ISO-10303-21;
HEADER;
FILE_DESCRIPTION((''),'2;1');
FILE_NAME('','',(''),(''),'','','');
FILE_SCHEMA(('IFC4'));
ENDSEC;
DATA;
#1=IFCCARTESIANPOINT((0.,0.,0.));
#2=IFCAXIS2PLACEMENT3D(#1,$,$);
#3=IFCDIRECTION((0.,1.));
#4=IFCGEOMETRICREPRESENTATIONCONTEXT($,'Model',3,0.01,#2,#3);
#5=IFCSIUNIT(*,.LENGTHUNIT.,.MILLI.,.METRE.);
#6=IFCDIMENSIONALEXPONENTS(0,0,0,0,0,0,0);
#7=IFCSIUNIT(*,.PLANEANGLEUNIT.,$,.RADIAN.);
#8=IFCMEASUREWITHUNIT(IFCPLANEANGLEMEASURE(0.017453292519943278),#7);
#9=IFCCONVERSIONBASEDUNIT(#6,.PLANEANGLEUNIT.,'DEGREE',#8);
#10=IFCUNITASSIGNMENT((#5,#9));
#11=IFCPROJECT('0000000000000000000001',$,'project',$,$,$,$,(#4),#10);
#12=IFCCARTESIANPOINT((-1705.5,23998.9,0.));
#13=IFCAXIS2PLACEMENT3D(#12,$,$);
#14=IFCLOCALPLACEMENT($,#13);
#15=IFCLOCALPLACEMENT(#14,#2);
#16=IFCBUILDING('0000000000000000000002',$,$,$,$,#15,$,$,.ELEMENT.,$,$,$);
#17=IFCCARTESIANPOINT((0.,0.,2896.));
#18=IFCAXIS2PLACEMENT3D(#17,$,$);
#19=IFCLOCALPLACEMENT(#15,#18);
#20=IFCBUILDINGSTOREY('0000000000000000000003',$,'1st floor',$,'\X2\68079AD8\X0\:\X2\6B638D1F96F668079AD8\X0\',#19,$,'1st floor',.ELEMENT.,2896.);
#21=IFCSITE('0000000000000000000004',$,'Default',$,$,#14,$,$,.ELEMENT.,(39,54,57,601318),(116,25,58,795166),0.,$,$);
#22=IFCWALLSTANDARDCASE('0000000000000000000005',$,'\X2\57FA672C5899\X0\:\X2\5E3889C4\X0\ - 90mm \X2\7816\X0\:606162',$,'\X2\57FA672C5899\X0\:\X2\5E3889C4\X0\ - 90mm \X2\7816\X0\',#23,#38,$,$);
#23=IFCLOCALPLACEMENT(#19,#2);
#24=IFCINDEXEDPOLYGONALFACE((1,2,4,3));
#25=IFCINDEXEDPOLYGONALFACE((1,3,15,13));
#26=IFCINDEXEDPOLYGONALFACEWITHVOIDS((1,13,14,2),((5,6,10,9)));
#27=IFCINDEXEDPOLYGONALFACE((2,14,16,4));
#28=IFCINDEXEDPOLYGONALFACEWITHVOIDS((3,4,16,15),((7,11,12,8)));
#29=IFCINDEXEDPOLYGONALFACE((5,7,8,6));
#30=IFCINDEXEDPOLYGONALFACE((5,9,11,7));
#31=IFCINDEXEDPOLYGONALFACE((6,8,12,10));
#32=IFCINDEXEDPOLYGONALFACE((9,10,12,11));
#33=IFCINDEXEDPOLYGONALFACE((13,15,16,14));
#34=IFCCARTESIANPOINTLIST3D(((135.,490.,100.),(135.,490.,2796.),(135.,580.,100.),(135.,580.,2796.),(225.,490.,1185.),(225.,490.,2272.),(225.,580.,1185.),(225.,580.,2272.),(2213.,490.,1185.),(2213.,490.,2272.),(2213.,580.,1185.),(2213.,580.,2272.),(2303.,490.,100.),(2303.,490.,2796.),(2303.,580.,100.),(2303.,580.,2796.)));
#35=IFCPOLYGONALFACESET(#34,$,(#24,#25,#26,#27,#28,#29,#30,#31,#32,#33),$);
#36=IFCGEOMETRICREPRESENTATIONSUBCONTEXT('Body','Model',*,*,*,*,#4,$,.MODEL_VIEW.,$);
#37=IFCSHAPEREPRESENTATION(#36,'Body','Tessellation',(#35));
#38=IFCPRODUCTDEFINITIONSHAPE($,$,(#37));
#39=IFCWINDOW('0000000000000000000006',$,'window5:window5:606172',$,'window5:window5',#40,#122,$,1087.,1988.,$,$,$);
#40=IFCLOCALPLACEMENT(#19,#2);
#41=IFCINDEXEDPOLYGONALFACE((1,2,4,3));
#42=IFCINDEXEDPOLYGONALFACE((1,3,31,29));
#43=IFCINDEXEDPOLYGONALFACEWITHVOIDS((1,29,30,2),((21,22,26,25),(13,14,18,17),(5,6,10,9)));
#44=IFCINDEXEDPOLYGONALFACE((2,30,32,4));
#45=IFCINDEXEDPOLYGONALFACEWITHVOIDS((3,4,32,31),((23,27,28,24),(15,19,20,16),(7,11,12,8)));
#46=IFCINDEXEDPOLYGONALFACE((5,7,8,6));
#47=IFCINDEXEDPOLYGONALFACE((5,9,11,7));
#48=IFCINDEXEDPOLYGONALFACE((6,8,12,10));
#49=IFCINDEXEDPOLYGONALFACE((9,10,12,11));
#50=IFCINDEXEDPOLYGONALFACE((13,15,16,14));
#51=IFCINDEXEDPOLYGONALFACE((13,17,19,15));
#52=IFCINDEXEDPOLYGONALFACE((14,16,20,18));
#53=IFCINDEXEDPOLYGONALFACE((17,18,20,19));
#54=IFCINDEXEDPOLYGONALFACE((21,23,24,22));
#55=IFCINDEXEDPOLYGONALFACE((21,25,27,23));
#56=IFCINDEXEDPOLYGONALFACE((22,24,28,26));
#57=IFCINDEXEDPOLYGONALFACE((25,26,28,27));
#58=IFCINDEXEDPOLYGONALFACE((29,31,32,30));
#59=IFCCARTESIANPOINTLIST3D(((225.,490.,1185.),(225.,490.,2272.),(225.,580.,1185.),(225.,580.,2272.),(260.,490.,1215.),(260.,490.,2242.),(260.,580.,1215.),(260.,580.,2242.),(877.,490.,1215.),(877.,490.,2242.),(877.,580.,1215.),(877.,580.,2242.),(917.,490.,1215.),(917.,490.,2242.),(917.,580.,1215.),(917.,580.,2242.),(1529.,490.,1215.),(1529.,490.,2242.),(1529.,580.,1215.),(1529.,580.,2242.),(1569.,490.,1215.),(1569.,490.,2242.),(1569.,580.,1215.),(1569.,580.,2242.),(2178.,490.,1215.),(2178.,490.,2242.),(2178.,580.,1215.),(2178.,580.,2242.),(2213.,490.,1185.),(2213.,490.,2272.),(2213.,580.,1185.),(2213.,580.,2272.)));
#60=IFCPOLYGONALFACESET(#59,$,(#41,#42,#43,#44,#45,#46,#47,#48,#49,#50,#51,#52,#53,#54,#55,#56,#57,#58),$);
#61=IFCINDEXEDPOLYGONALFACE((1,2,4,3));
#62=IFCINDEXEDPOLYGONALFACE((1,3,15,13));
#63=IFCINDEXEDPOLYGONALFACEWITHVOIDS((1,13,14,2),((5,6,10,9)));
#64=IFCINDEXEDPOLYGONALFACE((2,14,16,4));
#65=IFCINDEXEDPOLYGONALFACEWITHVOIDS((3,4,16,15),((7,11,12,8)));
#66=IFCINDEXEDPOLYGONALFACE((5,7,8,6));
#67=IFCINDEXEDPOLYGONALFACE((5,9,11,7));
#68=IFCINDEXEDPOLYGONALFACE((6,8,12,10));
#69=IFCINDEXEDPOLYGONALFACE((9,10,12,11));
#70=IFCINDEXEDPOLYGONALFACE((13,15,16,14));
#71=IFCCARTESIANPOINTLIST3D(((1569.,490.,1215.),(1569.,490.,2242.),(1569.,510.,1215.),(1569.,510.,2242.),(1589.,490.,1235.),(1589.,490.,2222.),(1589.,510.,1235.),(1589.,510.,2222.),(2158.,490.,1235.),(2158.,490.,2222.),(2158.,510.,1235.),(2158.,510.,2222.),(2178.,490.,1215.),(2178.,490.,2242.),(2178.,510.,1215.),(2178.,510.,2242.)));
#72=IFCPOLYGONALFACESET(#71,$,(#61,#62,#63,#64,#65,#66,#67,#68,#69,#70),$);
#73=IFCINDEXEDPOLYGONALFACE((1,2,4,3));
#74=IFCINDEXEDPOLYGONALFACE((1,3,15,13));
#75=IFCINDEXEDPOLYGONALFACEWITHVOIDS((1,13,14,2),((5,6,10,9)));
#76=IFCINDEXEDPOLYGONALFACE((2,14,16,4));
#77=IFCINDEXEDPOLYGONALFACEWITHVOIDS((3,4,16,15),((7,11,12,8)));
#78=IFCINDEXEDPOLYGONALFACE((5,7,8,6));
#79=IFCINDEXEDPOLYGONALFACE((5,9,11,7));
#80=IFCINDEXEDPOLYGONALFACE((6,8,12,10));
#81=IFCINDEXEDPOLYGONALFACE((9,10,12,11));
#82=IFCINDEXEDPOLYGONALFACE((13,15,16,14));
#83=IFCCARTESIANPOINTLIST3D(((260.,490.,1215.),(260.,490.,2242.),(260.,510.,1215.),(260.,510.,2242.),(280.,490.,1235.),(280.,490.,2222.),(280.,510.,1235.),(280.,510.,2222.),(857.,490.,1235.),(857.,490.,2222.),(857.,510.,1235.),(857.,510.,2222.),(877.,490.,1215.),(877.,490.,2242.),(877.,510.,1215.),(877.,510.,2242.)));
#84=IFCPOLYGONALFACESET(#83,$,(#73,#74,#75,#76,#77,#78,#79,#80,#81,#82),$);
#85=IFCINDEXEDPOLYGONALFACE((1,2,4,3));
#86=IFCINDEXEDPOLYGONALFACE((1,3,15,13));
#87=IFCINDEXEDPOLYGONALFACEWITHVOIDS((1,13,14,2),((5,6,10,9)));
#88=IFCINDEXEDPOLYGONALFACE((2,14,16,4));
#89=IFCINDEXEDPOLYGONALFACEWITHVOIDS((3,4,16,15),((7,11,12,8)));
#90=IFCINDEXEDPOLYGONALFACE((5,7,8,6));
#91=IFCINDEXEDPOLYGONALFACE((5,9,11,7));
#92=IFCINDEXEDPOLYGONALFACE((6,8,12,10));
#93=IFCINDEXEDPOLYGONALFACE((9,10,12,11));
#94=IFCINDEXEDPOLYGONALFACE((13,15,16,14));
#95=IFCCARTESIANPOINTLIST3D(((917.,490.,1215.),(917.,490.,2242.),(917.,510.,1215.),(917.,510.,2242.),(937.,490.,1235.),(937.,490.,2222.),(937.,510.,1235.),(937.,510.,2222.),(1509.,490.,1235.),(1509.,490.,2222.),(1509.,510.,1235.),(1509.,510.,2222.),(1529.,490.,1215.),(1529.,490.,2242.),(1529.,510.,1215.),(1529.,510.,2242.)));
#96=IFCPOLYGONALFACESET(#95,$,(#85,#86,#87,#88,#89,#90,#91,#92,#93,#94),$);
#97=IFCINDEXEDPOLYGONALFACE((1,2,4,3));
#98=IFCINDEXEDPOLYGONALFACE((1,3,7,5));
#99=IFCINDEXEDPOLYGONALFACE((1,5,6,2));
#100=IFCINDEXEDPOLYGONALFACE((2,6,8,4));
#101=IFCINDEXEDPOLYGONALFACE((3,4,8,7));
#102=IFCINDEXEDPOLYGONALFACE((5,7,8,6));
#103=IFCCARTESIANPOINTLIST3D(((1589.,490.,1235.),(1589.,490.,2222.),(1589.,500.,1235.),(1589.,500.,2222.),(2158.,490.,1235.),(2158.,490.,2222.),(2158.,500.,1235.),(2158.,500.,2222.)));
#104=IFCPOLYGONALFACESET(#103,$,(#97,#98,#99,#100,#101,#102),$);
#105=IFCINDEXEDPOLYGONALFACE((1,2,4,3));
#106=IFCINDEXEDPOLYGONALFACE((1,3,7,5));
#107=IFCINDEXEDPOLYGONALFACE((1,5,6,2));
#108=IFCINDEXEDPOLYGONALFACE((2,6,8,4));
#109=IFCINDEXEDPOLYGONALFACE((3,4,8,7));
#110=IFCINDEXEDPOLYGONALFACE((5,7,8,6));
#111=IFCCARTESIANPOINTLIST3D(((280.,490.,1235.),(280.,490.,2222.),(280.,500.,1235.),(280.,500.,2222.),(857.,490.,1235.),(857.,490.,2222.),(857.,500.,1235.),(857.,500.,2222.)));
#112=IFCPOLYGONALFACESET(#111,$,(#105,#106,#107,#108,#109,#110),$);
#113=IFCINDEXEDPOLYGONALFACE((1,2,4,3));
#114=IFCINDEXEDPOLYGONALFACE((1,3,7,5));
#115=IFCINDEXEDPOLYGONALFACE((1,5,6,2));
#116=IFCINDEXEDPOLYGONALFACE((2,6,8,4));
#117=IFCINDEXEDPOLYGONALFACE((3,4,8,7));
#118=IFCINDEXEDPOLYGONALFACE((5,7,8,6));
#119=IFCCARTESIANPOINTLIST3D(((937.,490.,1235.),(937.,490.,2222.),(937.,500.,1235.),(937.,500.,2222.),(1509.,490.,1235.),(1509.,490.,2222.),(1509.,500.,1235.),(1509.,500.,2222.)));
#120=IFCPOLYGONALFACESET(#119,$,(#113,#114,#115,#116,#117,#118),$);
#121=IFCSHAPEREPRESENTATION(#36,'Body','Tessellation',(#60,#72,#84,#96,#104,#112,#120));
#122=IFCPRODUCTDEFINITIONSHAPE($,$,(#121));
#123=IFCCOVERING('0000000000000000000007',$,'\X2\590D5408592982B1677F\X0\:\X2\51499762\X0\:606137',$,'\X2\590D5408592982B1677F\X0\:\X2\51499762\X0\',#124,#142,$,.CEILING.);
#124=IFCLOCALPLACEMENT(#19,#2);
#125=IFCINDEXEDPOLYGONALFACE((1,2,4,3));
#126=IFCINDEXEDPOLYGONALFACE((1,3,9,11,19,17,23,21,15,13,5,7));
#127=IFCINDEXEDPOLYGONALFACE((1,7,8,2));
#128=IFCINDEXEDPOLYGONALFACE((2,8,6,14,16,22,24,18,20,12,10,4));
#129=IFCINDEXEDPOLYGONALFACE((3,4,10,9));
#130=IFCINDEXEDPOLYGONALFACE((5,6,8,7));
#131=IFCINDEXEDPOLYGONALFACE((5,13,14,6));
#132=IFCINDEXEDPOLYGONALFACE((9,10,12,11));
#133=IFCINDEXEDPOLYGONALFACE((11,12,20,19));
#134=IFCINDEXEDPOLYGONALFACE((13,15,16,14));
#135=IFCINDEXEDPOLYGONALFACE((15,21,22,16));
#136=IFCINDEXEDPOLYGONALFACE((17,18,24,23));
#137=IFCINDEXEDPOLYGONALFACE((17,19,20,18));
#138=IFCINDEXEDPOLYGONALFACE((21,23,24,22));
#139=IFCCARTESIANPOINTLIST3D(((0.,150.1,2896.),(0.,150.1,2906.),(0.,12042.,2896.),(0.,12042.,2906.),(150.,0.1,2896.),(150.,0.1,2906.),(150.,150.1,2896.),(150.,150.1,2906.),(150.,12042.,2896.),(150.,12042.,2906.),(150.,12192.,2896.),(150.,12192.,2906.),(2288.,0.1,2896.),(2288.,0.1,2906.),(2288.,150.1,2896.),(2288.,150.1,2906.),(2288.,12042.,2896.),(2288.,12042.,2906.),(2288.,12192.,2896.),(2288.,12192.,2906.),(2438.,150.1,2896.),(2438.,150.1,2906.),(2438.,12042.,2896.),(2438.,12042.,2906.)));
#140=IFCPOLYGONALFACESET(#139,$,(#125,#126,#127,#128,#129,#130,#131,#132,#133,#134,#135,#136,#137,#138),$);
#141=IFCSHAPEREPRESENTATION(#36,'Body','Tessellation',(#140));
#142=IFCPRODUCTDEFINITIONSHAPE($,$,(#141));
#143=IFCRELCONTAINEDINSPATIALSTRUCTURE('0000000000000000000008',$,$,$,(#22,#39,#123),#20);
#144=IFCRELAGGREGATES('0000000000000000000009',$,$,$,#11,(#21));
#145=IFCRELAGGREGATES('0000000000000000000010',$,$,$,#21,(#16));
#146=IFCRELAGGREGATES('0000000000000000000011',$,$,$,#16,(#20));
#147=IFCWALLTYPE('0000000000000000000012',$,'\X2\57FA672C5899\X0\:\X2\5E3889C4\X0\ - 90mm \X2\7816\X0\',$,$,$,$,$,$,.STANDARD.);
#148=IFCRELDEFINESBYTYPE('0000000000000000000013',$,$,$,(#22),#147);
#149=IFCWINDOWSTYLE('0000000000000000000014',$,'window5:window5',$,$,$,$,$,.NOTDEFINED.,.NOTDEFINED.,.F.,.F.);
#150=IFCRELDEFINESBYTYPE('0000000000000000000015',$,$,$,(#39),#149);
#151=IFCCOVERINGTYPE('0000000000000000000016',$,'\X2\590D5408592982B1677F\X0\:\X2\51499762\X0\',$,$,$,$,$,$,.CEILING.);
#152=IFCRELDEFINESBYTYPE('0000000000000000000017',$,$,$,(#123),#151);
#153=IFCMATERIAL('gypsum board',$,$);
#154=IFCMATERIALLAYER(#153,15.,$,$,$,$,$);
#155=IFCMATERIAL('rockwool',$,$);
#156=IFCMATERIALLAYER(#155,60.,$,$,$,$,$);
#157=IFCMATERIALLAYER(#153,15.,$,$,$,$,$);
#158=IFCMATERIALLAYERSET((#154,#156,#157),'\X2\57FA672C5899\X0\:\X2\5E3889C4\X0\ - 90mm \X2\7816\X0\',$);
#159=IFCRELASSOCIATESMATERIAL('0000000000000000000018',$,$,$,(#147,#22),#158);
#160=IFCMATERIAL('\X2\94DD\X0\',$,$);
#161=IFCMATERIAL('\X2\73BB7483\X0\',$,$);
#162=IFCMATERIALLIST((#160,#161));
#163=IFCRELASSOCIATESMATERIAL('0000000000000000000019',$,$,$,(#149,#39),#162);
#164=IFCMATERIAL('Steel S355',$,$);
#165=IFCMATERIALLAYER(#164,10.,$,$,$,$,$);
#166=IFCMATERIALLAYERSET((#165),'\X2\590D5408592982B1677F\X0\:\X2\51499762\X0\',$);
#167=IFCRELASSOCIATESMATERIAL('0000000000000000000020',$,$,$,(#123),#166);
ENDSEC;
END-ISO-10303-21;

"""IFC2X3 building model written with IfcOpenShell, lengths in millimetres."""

from ifc_helpers import new_model, entity, si_unit, converted_unit, direction, frame, frame_2d, origin, place, context, subcontext, project, spatial, polyline, rectangle, outline, extrude, source, transform, mapped, material, material_list, layer, layer_set, layer_usage, type_object, type_shapes, element, fill, save


model = new_model("IFC2X3")

# Units and contexts
model_context = context("Model", 3, precision=0.01, world=origin(), true_north=direction((0.0, 1.0)))
body_context = subcontext(model_context, "Body", "Model", "MODEL_VIEW")
ifc_project = project(units=[si_unit("LENGTHUNIT", "METRE", prefix="MILLI"), converted_unit("PLANEANGLEUNIT", "DEGREE", entity("IfcPlaneAngleMeasure", 0.017453292519943278), si_unit("PLANEANGLEUNIT", "RADIAN"), dimensions=[0, 0, 0, 0, 0, 0, 0])], contexts=[model_context])

# Site, building, storey
site_placement = place(None, frame((-1705.5, 23998.9, 0.0)))
site = spatial("IfcSite", under=ifc_project, at=site_placement, Name="Default", CompositionType="ELEMENT", RefLatitude=(39, 54, 57, 601318), RefLongitude=(116, 25, 58, 795166), RefElevation=0.0)
building_placement = place(site_placement, origin())
building = spatial("IfcBuilding", under=site, at=building_placement, CompositionType="ELEMENT")
storey_placement = place(building_placement, frame((0.0, 0.0, 2896.0)))
storey = spatial("IfcBuildingStorey", under=building, at=storey_placement, Name="1st floor", ObjectType="标高:正负零标高", LongName="1st floor", CompositionType="ELEMENT", Elevation=2896.0)

# Shared definitions
ifc_material_1 = material(Name="Steel S355")

# Wall, opening, window
ifc_material_2 = material(Name="gypsum board")
ifc_layer_1 = layer(ifc_material_2, 15.0)
ifc_material_3 = material(Name="rockwool")
ifc_layer_2 = layer(ifc_material_3, 60.0)
ifc_layer_3 = layer(ifc_material_2, 15.0)
ifc_layer_set_1 = layer_set([ifc_layer_1, ifc_layer_2, ifc_layer_3], Name="基本墙:常规 - 90mm 砖")
ifc_layer_usage_1 = layer_usage(ifc_layer_set_1, "AXIS2", "NEGATIVE", 45.0)
wall_type = type_object("IfcWallType", Name="基本墙:常规 - 90mm 砖", PredefinedType="STANDARD", material=ifc_layer_set_1)
wall_placement = place(storey_placement, frame((2303.0, 535.0, 100.0), z_axis=(0.0, 0.0, 1.0), x_axis=(-1.0, 0.0, 0.0)))
wall = element("IfcWallStandardCase", 1, at=wall_placement, inside=storey, type_object=wall_type, material=ifc_layer_usage_1, Name="基本墙:常规 - 90mm 砖:606162", ObjectType="基本墙:常规 - 90mm 砖", context=body_context, shape_type="SweptSolid", body=[
    extrude(rectangle(XDim=2168.0, YDim=90.0, at=frame_2d((1084.0, 0.0), x_axis=(-1.0, 0.0))), origin(), (0.0, 0.0, 1.0), 2696.0),
])
opening_1_placement = place(wall_placement, frame((90.0, -45.0, 1085.0)))
opening_1 = element("IfcOpeningElement", 2, at=opening_1_placement, cuts=wall, ObjectType="Opening", context=body_context, shape_type="SweptSolid", body=[
    extrude(rectangle(XDim=1087.0, YDim=1988.0, at=frame_2d((543.5, 994.0), x_axis=(1.0, 0.0))), frame((0.0, 0.0, 0.0), z_axis=(0.0, 1.0, 0.0), x_axis=(0.0, 0.0, 1.0)), (0.0, 0.0, 1.0), 90.0),
])
ifc_material_4 = material(Name="铝")
ifc_material_5 = material(Name="玻璃")
ifc_material_list = material_list([ifc_material_4, ifc_material_5])
window_style = type_object("IfcWindowStyle", Name="window5:window5", ConstructionType="NOTDEFINED", OperationType="NOTDEFINED", ParameterTakesPrecedence=False, Sizeable=False, material=ifc_material_list)
shared_shape = source(origin(), body_context, "Body", "SweptSolid", [
    extrude(outline(polyline([(-994.0, -543.5), (994.0, -543.5), (994.0, 543.5), (-994.0, 543.5), (-994.0, -543.5)]), holes=[polyline([(-959.0, 513.5), (-342.0, 513.5), (-342.0, -513.5), (-959.0, -513.5), (-959.0, 513.5)]), polyline([(-302.0, 513.5), (310.0, 513.5), (310.0, -513.5), (-302.0, -513.5), (-302.0, 513.5)]), polyline([(350.0, 513.5), (959.0, 513.5), (959.0, -513.5), (350.0, -513.5), (350.0, 513.5)])]), frame((994.0, 0.0, 543.5), z_axis=(0.0, 1.0, 0.0), x_axis=(-1.0, 0.0, 0.0)), (0.0, 0.0, 1.0), 90.0),
    extrude(outline(polyline([(-304.5, -513.5), (304.5, -513.5), (304.5, 513.5), (-304.5, 513.5), (-304.5, -513.5)]), holes=[polyline([(-284.5, -493.5), (-284.5, 493.5), (284.5, 493.5), (284.5, -493.5), (-284.5, -493.5)])]), frame((339.5, 70.0, 543.5), z_axis=(0.0, 1.0, 0.0), x_axis=(1.0, 0.0, 0.0)), (0.0, 0.0, 1.0), 20.0),
    extrude(outline(polyline([(-308.5, -513.5), (308.5, -513.5), (308.5, 513.5), (-308.5, 513.5), (-308.5, -513.5)]), holes=[polyline([(-288.5, -493.5), (-288.5, 493.5), (288.5, 493.5), (288.5, -493.5), (-288.5, -493.5)])]), frame((1644.5, 70.0, 543.5), z_axis=(0.0, 1.0, 0.0), x_axis=(1.0, 0.0, 0.0)), (0.0, 0.0, 1.0), 20.0),
    extrude(outline(polyline([(-306.0, -513.5), (306.0, -513.5), (306.0, 513.5), (-306.0, 513.5), (-306.0, -513.5)]), holes=[polyline([(-286.0, -493.5), (-286.0, 493.5), (286.0, 493.5), (286.0, -493.5), (-286.0, -493.5)])]), frame((990.0, 70.0, 543.5), z_axis=(0.0, 1.0, 0.0), x_axis=(1.0, 0.0, 0.0)), (0.0, 0.0, 1.0), 20.0),
    extrude(rectangle(XDim=10.0, YDim=569.0, at=frame_2d((0.0, 0.0), x_axis=(1.0, 0.0))), frame((339.5, 85.0, 50.0), z_axis=(0.0, 0.0, 1.0), x_axis=(0.0, 1.0, 0.0)), (0.0, 0.0, 1.0), 987.0),
    extrude(rectangle(XDim=10.0, YDim=577.0, at=frame_2d((0.0, 0.0), x_axis=(1.0, 0.0))), frame((1644.5, 85.0, 50.0), z_axis=(0.0, 0.0, 1.0), x_axis=(0.0, 1.0, 0.0)), (0.0, 0.0, 1.0), 987.0),
    extrude(rectangle(XDim=10.0, YDim=572.0, at=frame_2d((0.0, 0.0), x_axis=(1.0, 0.0))), frame((990.0, 85.0, 50.0), z_axis=(0.0, 0.0, 1.0), x_axis=(0.0, 1.0, 0.0)), (0.0, 0.0, 1.0), 987.0),
])
type_shapes(window_style, [shared_shape])
window_placement = place(opening_1_placement, origin())
window = element("IfcWindow", 3, at=window_placement, inside=storey, type_object=window_style, material=ifc_material_list, Name="window5:window5:606172", ObjectType="window5:window5", OverallHeight=1087.0, OverallWidth=1988.0, context=body_context, shape_type="MappedRepresentation", body=[
    mapped(shared_shape, transform((0.0, 0.0, 0.0), scale=1.0)),
])
fill(opening_1, window)

# Covering
ifc_layer_4 = layer(ifc_material_1, 10.0)
ifc_layer_set_2 = layer_set([ifc_layer_4], Name="复合天花板:光面")
ifc_layer_usage_2 = layer_usage(ifc_layer_set_2, "AXIS3", "NEGATIVE", 10.0)
covering_type = type_object("IfcCoveringType", Name="复合天花板:光面", PredefinedType="CEILING")
covering_placement = place(storey_placement, origin())
element("IfcCovering", 4, at=covering_placement, inside=storey, type_object=covering_type, material=ifc_layer_usage_2, Name="复合天花板:光面:606137", ObjectType="复合天花板:光面", PredefinedType="CEILING", context=body_context, shape_type="SweptSolid", body=[
    extrude(outline(polyline([(5946.0, -1069.0), (6096.0, -1069.0), (6096.0, 1069.0), (5945.9, 1069.0), (5945.9, 1219.0), (-5946.0, 1219.0), (-5946.0, 1069.0), (-6096.0, 1069.0), (-6096.0, -1069.0), (-5946.0, -1069.0), (-5946.0, -1219.0), (5946.0, -1219.0), (5946.0, -1069.0)])), frame((1219.0, 6096.0, 2896.0), z_axis=(0.0, 0.0, 1.0), x_axis=(0.0, 1.0, 0.0)), (0.0, 0.0, 1.0), 10.0),
])

save(model, "model.ifc")
